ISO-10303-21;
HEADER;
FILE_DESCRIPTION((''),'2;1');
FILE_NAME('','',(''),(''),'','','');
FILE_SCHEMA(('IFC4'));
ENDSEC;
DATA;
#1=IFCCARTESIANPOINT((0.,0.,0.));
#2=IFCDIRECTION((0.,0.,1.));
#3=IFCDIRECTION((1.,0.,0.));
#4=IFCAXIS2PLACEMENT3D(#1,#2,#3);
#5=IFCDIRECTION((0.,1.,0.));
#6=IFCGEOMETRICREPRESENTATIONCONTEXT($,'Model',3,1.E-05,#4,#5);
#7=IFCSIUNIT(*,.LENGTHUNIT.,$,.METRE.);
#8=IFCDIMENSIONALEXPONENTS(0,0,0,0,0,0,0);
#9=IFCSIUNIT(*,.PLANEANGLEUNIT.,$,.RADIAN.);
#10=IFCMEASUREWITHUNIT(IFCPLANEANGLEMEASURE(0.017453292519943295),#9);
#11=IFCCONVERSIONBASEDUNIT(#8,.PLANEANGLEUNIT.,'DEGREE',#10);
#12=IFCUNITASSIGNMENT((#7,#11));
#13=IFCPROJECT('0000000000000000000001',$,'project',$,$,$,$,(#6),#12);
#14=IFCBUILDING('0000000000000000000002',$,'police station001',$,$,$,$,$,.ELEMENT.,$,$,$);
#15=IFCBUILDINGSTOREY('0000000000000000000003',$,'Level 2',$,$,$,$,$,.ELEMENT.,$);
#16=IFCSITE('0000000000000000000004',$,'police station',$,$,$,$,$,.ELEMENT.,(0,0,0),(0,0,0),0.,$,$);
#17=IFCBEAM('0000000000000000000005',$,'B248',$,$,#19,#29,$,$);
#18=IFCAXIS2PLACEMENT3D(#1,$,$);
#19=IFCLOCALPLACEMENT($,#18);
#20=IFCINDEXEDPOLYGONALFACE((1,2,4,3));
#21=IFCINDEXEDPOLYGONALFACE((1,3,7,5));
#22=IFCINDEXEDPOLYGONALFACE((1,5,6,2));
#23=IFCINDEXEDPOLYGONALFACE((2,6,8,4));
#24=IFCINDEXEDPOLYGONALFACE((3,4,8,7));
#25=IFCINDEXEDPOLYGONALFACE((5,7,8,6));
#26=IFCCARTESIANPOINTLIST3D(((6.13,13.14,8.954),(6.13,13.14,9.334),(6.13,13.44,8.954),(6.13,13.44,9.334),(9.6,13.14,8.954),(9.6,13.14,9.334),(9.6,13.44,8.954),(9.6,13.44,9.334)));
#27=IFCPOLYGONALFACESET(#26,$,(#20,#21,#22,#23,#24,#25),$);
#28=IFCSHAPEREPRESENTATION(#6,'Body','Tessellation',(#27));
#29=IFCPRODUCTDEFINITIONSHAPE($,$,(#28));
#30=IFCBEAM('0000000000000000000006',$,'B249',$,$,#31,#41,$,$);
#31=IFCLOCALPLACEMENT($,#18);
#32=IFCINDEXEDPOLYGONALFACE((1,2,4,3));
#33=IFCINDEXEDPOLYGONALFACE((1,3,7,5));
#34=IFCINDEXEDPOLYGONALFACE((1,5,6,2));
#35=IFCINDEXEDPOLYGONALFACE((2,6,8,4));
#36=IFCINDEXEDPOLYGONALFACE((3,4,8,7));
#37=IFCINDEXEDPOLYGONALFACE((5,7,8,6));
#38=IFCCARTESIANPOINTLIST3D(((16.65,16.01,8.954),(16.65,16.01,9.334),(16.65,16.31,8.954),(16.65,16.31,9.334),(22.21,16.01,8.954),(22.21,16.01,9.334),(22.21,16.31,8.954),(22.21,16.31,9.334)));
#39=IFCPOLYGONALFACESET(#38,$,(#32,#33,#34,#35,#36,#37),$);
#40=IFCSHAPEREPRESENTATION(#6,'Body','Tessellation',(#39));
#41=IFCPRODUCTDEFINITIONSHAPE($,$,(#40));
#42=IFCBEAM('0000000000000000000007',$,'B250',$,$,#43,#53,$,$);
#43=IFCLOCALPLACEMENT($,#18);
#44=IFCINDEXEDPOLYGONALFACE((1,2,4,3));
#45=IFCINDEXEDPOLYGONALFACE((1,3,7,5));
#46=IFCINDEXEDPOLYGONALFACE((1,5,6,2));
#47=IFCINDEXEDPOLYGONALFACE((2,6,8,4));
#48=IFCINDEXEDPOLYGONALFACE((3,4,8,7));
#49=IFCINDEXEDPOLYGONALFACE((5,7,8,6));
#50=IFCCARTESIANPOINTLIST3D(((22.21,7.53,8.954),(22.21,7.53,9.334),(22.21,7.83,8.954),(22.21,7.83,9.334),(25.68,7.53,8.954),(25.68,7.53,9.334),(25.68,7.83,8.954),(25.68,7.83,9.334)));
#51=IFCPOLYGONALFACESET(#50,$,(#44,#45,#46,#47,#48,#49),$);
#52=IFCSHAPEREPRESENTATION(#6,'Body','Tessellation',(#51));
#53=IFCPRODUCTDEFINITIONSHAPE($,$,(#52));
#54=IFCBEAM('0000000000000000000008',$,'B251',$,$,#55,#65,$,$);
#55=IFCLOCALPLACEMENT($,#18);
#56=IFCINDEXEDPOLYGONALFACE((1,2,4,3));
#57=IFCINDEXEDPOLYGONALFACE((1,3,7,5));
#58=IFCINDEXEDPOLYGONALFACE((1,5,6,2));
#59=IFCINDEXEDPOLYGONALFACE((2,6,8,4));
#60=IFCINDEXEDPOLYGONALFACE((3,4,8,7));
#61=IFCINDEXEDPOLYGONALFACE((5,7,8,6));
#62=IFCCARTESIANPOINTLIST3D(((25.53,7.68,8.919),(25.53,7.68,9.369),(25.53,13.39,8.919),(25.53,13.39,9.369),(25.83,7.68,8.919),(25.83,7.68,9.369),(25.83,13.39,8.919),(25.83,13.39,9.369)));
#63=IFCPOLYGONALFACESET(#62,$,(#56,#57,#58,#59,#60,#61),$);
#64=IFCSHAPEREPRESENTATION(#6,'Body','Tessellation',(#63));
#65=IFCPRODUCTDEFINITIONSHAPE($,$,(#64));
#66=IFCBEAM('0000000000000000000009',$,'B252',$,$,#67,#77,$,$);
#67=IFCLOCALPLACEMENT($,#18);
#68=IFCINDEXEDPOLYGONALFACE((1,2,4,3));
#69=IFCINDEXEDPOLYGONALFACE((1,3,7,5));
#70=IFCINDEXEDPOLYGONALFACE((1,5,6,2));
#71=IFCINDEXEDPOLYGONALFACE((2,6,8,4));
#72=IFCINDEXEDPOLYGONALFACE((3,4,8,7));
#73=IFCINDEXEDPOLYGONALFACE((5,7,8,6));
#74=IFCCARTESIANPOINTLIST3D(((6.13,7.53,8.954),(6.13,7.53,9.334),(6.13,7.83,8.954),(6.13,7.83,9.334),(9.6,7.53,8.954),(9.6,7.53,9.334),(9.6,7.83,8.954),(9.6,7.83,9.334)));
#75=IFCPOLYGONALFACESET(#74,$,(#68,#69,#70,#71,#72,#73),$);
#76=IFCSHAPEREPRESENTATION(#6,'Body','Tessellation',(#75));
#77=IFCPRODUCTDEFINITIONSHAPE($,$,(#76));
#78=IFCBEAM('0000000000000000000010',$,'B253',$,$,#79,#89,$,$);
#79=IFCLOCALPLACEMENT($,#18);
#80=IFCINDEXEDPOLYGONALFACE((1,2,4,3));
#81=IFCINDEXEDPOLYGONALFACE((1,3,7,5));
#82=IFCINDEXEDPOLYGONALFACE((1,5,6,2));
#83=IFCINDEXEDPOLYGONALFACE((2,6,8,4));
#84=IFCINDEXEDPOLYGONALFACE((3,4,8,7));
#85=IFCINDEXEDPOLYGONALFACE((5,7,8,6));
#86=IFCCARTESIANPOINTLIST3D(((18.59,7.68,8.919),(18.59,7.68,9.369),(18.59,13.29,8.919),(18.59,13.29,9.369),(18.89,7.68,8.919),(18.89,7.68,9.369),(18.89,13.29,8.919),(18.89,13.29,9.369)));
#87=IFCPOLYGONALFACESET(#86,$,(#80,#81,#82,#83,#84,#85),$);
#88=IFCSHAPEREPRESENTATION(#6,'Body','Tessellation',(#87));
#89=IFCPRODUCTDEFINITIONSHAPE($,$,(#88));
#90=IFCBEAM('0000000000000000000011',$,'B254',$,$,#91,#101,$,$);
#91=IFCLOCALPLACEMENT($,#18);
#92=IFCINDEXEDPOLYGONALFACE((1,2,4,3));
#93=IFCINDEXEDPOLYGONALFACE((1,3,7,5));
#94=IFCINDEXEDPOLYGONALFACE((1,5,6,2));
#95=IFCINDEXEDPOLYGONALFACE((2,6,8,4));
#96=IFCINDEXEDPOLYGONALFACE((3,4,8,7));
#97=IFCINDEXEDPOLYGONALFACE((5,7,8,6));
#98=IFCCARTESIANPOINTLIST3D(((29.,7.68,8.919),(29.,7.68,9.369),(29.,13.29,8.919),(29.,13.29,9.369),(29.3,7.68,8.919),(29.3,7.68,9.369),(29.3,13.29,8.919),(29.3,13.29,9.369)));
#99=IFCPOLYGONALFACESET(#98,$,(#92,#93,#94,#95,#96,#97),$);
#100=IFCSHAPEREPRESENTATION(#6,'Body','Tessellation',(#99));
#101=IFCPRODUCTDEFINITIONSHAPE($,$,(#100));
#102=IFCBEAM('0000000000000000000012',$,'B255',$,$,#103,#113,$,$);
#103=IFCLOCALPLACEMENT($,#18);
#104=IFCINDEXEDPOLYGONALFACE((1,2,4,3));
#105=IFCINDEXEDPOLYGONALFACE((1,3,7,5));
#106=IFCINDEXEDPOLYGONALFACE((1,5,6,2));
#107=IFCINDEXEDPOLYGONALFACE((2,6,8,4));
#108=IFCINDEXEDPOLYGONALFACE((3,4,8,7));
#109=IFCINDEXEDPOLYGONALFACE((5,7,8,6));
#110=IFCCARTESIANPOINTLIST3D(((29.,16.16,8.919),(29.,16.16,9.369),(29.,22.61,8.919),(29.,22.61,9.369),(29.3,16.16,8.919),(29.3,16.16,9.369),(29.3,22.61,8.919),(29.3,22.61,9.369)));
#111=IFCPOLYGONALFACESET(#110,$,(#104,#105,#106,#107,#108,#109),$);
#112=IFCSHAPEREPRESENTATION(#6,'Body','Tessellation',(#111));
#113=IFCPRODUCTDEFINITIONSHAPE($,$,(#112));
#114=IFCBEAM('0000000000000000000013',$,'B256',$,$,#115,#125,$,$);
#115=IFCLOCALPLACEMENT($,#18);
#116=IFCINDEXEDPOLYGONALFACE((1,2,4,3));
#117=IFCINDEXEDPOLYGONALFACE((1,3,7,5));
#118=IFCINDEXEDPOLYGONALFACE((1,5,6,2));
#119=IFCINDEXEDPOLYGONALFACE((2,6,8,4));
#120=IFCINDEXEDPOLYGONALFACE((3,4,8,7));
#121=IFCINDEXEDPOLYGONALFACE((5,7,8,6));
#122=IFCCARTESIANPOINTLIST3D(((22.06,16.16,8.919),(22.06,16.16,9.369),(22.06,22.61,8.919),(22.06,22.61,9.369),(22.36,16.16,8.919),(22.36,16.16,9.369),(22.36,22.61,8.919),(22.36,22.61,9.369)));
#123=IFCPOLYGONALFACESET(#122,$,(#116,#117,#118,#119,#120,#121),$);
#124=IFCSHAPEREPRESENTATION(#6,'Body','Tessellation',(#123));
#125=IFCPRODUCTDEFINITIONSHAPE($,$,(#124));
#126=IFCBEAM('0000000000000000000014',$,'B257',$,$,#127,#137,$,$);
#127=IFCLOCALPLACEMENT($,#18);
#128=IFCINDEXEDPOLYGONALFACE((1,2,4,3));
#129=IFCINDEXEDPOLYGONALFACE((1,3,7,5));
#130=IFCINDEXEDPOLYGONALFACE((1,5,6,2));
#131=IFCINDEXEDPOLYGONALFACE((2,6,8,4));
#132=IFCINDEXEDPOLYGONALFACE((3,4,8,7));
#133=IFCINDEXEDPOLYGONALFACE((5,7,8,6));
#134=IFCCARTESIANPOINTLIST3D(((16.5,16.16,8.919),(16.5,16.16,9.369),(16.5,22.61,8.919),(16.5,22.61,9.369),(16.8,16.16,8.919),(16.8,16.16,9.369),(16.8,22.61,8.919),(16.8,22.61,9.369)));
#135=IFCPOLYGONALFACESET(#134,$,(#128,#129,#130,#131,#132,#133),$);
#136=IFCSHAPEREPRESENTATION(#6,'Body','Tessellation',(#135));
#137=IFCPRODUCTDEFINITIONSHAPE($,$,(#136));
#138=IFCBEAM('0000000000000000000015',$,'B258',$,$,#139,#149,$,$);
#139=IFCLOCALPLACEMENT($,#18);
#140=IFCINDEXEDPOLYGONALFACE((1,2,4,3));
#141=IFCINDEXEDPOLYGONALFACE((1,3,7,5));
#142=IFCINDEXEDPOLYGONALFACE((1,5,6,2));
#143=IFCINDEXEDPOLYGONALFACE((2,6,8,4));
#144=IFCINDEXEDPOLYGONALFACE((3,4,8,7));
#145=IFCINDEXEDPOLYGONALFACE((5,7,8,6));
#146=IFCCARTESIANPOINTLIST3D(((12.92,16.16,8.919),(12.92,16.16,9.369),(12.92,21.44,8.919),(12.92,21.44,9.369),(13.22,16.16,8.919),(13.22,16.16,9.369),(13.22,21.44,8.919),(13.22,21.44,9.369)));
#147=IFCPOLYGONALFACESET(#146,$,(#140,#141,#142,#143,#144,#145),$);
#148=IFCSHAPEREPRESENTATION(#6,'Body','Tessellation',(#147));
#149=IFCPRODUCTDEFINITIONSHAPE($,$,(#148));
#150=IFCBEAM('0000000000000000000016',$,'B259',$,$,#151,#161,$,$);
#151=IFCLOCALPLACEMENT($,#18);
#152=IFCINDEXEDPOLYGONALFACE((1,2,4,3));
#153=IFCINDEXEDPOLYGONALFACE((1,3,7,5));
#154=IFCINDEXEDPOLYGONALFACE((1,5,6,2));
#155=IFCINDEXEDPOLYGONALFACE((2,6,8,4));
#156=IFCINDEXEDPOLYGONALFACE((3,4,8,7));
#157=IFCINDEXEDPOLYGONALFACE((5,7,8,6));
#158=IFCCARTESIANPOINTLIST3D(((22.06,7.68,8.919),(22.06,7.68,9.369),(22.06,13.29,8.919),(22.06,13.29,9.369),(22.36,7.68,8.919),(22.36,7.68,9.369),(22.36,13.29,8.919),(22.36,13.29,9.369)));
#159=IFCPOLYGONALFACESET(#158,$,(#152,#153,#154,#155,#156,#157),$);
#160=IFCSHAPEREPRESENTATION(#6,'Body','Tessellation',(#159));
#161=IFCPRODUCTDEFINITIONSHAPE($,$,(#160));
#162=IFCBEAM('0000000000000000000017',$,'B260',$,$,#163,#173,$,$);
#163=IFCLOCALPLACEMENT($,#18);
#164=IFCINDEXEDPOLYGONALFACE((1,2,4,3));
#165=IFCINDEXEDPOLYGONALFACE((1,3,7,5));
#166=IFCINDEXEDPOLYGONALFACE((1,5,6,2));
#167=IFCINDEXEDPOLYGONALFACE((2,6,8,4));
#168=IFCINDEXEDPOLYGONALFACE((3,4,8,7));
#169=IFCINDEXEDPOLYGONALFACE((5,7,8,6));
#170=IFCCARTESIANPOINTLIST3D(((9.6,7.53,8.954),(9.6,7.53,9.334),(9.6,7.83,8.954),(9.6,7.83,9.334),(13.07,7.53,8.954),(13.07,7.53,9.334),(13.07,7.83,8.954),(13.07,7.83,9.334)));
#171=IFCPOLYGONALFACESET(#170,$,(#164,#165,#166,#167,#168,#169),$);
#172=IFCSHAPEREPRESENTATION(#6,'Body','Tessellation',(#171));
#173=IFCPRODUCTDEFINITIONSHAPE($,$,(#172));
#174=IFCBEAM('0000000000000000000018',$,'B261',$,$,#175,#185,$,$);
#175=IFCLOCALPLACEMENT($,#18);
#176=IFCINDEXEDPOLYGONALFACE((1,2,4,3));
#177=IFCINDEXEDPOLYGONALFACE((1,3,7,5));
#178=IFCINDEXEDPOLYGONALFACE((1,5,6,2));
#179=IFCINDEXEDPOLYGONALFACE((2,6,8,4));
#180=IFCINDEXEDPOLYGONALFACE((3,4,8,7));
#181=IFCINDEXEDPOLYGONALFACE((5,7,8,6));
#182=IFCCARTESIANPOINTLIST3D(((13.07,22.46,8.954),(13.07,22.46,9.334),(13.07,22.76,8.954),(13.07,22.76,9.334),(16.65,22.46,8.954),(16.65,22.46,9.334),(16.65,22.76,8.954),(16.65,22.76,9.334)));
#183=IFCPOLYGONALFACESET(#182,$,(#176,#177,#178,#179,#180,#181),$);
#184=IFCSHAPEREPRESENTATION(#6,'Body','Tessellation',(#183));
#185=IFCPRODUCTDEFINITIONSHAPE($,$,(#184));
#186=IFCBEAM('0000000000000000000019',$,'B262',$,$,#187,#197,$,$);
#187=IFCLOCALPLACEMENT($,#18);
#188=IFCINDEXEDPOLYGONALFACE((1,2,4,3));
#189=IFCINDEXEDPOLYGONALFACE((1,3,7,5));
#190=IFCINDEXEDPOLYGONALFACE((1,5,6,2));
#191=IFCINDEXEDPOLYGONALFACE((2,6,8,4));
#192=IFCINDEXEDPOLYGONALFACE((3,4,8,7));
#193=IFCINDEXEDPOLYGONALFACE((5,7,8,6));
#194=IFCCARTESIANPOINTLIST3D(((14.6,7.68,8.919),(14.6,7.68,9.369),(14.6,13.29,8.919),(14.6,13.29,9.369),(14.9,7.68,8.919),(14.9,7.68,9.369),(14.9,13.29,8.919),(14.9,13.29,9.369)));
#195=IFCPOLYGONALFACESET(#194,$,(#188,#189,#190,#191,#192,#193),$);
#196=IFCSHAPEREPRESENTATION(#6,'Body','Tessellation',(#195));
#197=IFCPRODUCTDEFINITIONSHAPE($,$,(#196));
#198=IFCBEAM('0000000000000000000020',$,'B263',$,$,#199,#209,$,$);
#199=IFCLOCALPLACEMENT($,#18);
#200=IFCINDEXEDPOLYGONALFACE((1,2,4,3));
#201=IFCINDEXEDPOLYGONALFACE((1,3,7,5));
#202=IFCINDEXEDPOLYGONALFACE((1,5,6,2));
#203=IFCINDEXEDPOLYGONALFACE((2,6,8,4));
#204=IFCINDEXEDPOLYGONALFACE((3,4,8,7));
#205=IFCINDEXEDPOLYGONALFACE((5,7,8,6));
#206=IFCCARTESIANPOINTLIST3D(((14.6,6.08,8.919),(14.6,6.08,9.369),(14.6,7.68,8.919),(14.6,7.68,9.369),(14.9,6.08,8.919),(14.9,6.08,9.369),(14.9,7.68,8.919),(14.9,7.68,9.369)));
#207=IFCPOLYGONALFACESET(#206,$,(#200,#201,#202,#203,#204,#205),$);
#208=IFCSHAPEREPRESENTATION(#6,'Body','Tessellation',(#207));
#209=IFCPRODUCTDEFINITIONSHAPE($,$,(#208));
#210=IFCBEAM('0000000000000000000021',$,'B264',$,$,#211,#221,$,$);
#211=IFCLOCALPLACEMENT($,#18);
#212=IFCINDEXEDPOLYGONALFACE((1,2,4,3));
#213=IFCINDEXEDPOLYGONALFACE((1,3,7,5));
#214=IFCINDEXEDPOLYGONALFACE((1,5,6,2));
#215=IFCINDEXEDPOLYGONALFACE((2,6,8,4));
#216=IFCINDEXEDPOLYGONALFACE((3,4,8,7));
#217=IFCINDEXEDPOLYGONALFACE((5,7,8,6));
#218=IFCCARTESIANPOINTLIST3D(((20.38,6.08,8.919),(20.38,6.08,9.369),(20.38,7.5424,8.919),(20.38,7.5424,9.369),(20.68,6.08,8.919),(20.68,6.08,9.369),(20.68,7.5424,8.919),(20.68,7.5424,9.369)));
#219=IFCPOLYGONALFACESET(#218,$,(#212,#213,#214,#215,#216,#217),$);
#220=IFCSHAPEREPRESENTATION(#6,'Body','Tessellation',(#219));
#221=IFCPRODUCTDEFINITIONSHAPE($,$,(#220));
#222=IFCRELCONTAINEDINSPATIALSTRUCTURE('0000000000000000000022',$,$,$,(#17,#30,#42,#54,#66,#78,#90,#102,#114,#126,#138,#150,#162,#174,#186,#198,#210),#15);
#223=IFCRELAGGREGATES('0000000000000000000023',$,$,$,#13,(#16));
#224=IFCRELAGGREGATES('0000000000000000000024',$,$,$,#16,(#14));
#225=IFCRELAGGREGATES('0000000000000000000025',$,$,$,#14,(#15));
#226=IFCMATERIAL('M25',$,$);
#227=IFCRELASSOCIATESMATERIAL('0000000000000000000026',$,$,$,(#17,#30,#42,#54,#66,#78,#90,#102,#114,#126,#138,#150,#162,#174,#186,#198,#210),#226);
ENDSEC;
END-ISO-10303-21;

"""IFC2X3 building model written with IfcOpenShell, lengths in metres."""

from ifc_helpers import new_model, entity, si_unit, converted_unit, direction, frame, frame_2d, origin_with_axes, place, context, project, spatial, rectangle, extrude, material, element, save


model = new_model("IFC2X3")

# Units and contexts
model_context = context("Model", 3, precision=1e-05, world=origin_with_axes(), true_north=direction((0.0, 1.0, 0.0)))
ifc_project = project(units=[si_unit("LENGTHUNIT", "METRE"), converted_unit("PLANEANGLEUNIT", "DEGREE", entity("IfcPlaneAngleMeasure", 0.017453292519943295), si_unit("PLANEANGLEUNIT", "RADIAN"), dimensions=[0, 0, 0, 0, 0, 0, 0])], contexts=[model_context])

# Site, building, storey
site = spatial("IfcSite", under=ifc_project, Name="police station", CompositionType="ELEMENT", RefLatitude=(0, 0, 0), RefLongitude=(0, 0, 0), RefElevation=0.0)
building = spatial("IfcBuilding", under=site, Name="police station001", CompositionType="ELEMENT")
storey = spatial("IfcBuildingStorey", under=building, Name="Level 2", CompositionType="ELEMENT")

# Beams
ifc_material = material(Name="M25")
placement = place(None, origin_with_axes())
element("IfcBeam", 1, at=placement, inside=storey, material=ifc_material, Name="B248", context=model_context, shape_type="SweptSolid", body=[
    extrude(rectangle(XDim=0.3, YDim=0.38, at=frame_2d((0.0, 0.0), x_axis=(0.0, 1.0, 0.0))), frame((9.6, 13.29, 9.144), z_axis=(-1.0, 0.0, 0.0), x_axis=(0.0, 0.0, -1.0)), (0.0, 0.0, 1.0), 3.47),
])
element("IfcBeam", 2, at=placement, inside=storey, material=ifc_material, Name="B249", context=model_context, shape_type="SweptSolid", body=[
    extrude(rectangle(XDim=0.3, YDim=0.38, at=frame_2d((0.0, 0.0), x_axis=(0.0, 1.0, 0.0))), frame((22.21, 16.16, 9.144), z_axis=(-1.0, 0.0, 0.0), x_axis=(0.0, 0.0, -1.0)), (0.0, 0.0, 1.0), 5.56),
])
element("IfcBeam", 3, at=placement, inside=storey, material=ifc_material, Name="B250", context=model_context, shape_type="SweptSolid", body=[
    extrude(rectangle(XDim=0.3, YDim=0.38, at=frame_2d((0.0, 0.0), x_axis=(0.0, 1.0, 0.0))), frame((25.68, 7.68, 9.144), z_axis=(-1.0, 0.0, 0.0), x_axis=(0.0, 0.0, -1.0)), (0.0, 0.0, 1.0), 3.47),
])
element("IfcBeam", 4, at=placement, inside=storey, material=ifc_material, Name="B251", context=model_context, shape_type="SweptSolid", body=[
    extrude(rectangle(XDim=0.3, YDim=0.45, at=frame_2d((0.0, 0.0), x_axis=(0.0, 1.0, 0.0))), frame((25.68, 7.68, 9.144), z_axis=(0.0, 1.0, 0.0), x_axis=(0.0, 0.0, -1.0)), (0.0, 0.0, 1.0), 5.71),
])
element("IfcBeam", 5, at=placement, inside=storey, material=ifc_material, Name="B252", context=model_context, shape_type="SweptSolid", body=[
    extrude(rectangle(XDim=0.3, YDim=0.38, at=frame_2d((0.0, 0.0), x_axis=(0.0, 1.0, 0.0))), frame((6.13, 7.68, 9.144), z_axis=(1.0, 0.0, 0.0), x_axis=(0.0, 0.0, -1.0)), (0.0, 0.0, 1.0), 3.47),
])
element("IfcBeam", 6, at=placement, inside=storey, material=ifc_material, Name="B253", context=model_context, shape_type="SweptSolid", body=[
    extrude(rectangle(XDim=0.3, YDim=0.45, at=frame_2d((0.0, 0.0), x_axis=(0.0, 1.0, 0.0))), frame((18.74, 13.29, 9.144), z_axis=(0.0, -1.0, 0.0), x_axis=(0.0, 0.0, -1.0)), (0.0, 0.0, 1.0), 5.61),
])
element("IfcBeam", 7, at=placement, inside=storey, material=ifc_material, Name="B254", context=model_context, shape_type="SweptSolid", body=[
    extrude(rectangle(XDim=0.3, YDim=0.45, at=frame_2d((0.0, 0.0), x_axis=(0.0, 1.0, 0.0))), frame((29.15, 13.29, 9.144), z_axis=(0.0, -1.0, 0.0), x_axis=(0.0, 0.0, -1.0)), (0.0, 0.0, 1.0), 5.61),
])
element("IfcBeam", 8, at=placement, inside=storey, material=ifc_material, Name="B255", context=model_context, shape_type="SweptSolid", body=[
    extrude(rectangle(XDim=0.3, YDim=0.45, at=frame_2d((0.0, 0.0), x_axis=(0.0, 1.0, 0.0))), frame((29.15, 16.16, 9.144), z_axis=(0.0, 1.0, 0.0), x_axis=(0.0, 0.0, -1.0)), (0.0, 0.0, 1.0), 6.45),
])
element("IfcBeam", 9, at=placement, inside=storey, material=ifc_material, Name="B256", context=model_context, shape_type="SweptSolid", body=[
    extrude(rectangle(XDim=0.3, YDim=0.45, at=frame_2d((0.0, 0.0), x_axis=(0.0, 1.0, 0.0))), frame((22.21, 16.16, 9.144), z_axis=(0.0, 1.0, 0.0), x_axis=(0.0, 0.0, -1.0)), (0.0, 0.0, 1.0), 6.45),
])
element("IfcBeam", 10, at=placement, inside=storey, material=ifc_material, Name="B257", context=model_context, shape_type="SweptSolid", body=[
    extrude(rectangle(XDim=0.3, YDim=0.45, at=frame_2d((0.0, 0.0), x_axis=(0.0, 1.0, 0.0))), frame((16.65, 16.16, 9.144), z_axis=(0.0, 1.0, 0.0), x_axis=(0.0, 0.0, -1.0)), (0.0, 0.0, 1.0), 6.45),
])
element("IfcBeam", 11, at=placement, inside=storey, material=ifc_material, Name="B258", context=model_context, shape_type="SweptSolid", body=[
    extrude(rectangle(XDim=0.3, YDim=0.45, at=frame_2d((0.0, 0.0), x_axis=(0.0, 1.0, 0.0))), frame((13.07, 16.16, 9.144), z_axis=(0.0, 1.0, 0.0), x_axis=(0.0, 0.0, -1.0)), (0.0, 0.0, 1.0), 5.28),
])
element("IfcBeam", 12, at=placement, inside=storey, material=ifc_material, Name="B259", context=model_context, shape_type="SweptSolid", body=[
    extrude(rectangle(XDim=0.3, YDim=0.45, at=frame_2d((0.0, 0.0), x_axis=(0.0, 1.0, 0.0))), frame((22.21, 7.68, 9.144), z_axis=(0.0, 1.0, 0.0), x_axis=(0.0, 0.0, -1.0)), (0.0, 0.0, 1.0), 5.61),
])
element("IfcBeam", 13, at=placement, inside=storey, material=ifc_material, Name="B260", context=model_context, shape_type="SweptSolid", body=[
    extrude(rectangle(XDim=0.3, YDim=0.38, at=frame_2d((0.0, 0.0), x_axis=(0.0, 1.0, 0.0))), frame((9.6, 7.68, 9.144), z_axis=(1.0, 0.0, 0.0), x_axis=(0.0, 0.0, -1.0)), (0.0, 0.0, 1.0), 3.47),
])
element("IfcBeam", 14, at=placement, inside=storey, material=ifc_material, Name="B261", context=model_context, shape_type="SweptSolid", body=[
    extrude(rectangle(XDim=0.3, YDim=0.38, at=frame_2d((0.0, 0.0), x_axis=(0.0, 1.0, 0.0))), frame((13.07, 22.61, 9.144), z_axis=(1.0, 0.0, 0.0), x_axis=(0.0, 0.0, -1.0)), (0.0, 0.0, 1.0), 3.58),
])
element("IfcBeam", 15, at=placement, inside=storey, material=ifc_material, Name="B262", context=model_context, shape_type="SweptSolid", body=[
    extrude(rectangle(XDim=0.3, YDim=0.45, at=frame_2d((0.0, 0.0), x_axis=(0.0, 1.0, 0.0))), frame((14.75, 7.68, 9.144), z_axis=(0.0, 1.0, 0.0), x_axis=(0.0, 0.0, -1.0)), (0.0, 0.0, 1.0), 5.61),
])
element("IfcBeam", 16, at=placement, inside=storey, material=ifc_material, Name="B263", context=model_context, shape_type="SweptSolid", body=[
    extrude(rectangle(XDim=0.3, YDim=0.45, at=frame_2d((0.0, 0.0), x_axis=(0.0, 1.0, 0.0))), frame((14.75, 6.08, 9.144), z_axis=(0.0, 1.0, 0.0), x_axis=(0.0, 0.0, -1.0)), (0.0, 0.0, 1.0), 1.6),
])
element("IfcBeam", 17, at=placement, inside=storey, material=ifc_material, Name="B264", context=model_context, shape_type="SweptSolid", body=[
    extrude(rectangle(XDim=0.3, YDim=0.45, at=frame_2d((0.0, 0.0), x_axis=(0.0, 1.0, 0.0))), frame((20.53, 6.08, 9.144), z_axis=(0.0, 1.0, 0.0), x_axis=(0.0, 0.0, -1.0)), (0.0, 0.0, 1.0), 1.4624),
])

save(model, "model.ifc")
